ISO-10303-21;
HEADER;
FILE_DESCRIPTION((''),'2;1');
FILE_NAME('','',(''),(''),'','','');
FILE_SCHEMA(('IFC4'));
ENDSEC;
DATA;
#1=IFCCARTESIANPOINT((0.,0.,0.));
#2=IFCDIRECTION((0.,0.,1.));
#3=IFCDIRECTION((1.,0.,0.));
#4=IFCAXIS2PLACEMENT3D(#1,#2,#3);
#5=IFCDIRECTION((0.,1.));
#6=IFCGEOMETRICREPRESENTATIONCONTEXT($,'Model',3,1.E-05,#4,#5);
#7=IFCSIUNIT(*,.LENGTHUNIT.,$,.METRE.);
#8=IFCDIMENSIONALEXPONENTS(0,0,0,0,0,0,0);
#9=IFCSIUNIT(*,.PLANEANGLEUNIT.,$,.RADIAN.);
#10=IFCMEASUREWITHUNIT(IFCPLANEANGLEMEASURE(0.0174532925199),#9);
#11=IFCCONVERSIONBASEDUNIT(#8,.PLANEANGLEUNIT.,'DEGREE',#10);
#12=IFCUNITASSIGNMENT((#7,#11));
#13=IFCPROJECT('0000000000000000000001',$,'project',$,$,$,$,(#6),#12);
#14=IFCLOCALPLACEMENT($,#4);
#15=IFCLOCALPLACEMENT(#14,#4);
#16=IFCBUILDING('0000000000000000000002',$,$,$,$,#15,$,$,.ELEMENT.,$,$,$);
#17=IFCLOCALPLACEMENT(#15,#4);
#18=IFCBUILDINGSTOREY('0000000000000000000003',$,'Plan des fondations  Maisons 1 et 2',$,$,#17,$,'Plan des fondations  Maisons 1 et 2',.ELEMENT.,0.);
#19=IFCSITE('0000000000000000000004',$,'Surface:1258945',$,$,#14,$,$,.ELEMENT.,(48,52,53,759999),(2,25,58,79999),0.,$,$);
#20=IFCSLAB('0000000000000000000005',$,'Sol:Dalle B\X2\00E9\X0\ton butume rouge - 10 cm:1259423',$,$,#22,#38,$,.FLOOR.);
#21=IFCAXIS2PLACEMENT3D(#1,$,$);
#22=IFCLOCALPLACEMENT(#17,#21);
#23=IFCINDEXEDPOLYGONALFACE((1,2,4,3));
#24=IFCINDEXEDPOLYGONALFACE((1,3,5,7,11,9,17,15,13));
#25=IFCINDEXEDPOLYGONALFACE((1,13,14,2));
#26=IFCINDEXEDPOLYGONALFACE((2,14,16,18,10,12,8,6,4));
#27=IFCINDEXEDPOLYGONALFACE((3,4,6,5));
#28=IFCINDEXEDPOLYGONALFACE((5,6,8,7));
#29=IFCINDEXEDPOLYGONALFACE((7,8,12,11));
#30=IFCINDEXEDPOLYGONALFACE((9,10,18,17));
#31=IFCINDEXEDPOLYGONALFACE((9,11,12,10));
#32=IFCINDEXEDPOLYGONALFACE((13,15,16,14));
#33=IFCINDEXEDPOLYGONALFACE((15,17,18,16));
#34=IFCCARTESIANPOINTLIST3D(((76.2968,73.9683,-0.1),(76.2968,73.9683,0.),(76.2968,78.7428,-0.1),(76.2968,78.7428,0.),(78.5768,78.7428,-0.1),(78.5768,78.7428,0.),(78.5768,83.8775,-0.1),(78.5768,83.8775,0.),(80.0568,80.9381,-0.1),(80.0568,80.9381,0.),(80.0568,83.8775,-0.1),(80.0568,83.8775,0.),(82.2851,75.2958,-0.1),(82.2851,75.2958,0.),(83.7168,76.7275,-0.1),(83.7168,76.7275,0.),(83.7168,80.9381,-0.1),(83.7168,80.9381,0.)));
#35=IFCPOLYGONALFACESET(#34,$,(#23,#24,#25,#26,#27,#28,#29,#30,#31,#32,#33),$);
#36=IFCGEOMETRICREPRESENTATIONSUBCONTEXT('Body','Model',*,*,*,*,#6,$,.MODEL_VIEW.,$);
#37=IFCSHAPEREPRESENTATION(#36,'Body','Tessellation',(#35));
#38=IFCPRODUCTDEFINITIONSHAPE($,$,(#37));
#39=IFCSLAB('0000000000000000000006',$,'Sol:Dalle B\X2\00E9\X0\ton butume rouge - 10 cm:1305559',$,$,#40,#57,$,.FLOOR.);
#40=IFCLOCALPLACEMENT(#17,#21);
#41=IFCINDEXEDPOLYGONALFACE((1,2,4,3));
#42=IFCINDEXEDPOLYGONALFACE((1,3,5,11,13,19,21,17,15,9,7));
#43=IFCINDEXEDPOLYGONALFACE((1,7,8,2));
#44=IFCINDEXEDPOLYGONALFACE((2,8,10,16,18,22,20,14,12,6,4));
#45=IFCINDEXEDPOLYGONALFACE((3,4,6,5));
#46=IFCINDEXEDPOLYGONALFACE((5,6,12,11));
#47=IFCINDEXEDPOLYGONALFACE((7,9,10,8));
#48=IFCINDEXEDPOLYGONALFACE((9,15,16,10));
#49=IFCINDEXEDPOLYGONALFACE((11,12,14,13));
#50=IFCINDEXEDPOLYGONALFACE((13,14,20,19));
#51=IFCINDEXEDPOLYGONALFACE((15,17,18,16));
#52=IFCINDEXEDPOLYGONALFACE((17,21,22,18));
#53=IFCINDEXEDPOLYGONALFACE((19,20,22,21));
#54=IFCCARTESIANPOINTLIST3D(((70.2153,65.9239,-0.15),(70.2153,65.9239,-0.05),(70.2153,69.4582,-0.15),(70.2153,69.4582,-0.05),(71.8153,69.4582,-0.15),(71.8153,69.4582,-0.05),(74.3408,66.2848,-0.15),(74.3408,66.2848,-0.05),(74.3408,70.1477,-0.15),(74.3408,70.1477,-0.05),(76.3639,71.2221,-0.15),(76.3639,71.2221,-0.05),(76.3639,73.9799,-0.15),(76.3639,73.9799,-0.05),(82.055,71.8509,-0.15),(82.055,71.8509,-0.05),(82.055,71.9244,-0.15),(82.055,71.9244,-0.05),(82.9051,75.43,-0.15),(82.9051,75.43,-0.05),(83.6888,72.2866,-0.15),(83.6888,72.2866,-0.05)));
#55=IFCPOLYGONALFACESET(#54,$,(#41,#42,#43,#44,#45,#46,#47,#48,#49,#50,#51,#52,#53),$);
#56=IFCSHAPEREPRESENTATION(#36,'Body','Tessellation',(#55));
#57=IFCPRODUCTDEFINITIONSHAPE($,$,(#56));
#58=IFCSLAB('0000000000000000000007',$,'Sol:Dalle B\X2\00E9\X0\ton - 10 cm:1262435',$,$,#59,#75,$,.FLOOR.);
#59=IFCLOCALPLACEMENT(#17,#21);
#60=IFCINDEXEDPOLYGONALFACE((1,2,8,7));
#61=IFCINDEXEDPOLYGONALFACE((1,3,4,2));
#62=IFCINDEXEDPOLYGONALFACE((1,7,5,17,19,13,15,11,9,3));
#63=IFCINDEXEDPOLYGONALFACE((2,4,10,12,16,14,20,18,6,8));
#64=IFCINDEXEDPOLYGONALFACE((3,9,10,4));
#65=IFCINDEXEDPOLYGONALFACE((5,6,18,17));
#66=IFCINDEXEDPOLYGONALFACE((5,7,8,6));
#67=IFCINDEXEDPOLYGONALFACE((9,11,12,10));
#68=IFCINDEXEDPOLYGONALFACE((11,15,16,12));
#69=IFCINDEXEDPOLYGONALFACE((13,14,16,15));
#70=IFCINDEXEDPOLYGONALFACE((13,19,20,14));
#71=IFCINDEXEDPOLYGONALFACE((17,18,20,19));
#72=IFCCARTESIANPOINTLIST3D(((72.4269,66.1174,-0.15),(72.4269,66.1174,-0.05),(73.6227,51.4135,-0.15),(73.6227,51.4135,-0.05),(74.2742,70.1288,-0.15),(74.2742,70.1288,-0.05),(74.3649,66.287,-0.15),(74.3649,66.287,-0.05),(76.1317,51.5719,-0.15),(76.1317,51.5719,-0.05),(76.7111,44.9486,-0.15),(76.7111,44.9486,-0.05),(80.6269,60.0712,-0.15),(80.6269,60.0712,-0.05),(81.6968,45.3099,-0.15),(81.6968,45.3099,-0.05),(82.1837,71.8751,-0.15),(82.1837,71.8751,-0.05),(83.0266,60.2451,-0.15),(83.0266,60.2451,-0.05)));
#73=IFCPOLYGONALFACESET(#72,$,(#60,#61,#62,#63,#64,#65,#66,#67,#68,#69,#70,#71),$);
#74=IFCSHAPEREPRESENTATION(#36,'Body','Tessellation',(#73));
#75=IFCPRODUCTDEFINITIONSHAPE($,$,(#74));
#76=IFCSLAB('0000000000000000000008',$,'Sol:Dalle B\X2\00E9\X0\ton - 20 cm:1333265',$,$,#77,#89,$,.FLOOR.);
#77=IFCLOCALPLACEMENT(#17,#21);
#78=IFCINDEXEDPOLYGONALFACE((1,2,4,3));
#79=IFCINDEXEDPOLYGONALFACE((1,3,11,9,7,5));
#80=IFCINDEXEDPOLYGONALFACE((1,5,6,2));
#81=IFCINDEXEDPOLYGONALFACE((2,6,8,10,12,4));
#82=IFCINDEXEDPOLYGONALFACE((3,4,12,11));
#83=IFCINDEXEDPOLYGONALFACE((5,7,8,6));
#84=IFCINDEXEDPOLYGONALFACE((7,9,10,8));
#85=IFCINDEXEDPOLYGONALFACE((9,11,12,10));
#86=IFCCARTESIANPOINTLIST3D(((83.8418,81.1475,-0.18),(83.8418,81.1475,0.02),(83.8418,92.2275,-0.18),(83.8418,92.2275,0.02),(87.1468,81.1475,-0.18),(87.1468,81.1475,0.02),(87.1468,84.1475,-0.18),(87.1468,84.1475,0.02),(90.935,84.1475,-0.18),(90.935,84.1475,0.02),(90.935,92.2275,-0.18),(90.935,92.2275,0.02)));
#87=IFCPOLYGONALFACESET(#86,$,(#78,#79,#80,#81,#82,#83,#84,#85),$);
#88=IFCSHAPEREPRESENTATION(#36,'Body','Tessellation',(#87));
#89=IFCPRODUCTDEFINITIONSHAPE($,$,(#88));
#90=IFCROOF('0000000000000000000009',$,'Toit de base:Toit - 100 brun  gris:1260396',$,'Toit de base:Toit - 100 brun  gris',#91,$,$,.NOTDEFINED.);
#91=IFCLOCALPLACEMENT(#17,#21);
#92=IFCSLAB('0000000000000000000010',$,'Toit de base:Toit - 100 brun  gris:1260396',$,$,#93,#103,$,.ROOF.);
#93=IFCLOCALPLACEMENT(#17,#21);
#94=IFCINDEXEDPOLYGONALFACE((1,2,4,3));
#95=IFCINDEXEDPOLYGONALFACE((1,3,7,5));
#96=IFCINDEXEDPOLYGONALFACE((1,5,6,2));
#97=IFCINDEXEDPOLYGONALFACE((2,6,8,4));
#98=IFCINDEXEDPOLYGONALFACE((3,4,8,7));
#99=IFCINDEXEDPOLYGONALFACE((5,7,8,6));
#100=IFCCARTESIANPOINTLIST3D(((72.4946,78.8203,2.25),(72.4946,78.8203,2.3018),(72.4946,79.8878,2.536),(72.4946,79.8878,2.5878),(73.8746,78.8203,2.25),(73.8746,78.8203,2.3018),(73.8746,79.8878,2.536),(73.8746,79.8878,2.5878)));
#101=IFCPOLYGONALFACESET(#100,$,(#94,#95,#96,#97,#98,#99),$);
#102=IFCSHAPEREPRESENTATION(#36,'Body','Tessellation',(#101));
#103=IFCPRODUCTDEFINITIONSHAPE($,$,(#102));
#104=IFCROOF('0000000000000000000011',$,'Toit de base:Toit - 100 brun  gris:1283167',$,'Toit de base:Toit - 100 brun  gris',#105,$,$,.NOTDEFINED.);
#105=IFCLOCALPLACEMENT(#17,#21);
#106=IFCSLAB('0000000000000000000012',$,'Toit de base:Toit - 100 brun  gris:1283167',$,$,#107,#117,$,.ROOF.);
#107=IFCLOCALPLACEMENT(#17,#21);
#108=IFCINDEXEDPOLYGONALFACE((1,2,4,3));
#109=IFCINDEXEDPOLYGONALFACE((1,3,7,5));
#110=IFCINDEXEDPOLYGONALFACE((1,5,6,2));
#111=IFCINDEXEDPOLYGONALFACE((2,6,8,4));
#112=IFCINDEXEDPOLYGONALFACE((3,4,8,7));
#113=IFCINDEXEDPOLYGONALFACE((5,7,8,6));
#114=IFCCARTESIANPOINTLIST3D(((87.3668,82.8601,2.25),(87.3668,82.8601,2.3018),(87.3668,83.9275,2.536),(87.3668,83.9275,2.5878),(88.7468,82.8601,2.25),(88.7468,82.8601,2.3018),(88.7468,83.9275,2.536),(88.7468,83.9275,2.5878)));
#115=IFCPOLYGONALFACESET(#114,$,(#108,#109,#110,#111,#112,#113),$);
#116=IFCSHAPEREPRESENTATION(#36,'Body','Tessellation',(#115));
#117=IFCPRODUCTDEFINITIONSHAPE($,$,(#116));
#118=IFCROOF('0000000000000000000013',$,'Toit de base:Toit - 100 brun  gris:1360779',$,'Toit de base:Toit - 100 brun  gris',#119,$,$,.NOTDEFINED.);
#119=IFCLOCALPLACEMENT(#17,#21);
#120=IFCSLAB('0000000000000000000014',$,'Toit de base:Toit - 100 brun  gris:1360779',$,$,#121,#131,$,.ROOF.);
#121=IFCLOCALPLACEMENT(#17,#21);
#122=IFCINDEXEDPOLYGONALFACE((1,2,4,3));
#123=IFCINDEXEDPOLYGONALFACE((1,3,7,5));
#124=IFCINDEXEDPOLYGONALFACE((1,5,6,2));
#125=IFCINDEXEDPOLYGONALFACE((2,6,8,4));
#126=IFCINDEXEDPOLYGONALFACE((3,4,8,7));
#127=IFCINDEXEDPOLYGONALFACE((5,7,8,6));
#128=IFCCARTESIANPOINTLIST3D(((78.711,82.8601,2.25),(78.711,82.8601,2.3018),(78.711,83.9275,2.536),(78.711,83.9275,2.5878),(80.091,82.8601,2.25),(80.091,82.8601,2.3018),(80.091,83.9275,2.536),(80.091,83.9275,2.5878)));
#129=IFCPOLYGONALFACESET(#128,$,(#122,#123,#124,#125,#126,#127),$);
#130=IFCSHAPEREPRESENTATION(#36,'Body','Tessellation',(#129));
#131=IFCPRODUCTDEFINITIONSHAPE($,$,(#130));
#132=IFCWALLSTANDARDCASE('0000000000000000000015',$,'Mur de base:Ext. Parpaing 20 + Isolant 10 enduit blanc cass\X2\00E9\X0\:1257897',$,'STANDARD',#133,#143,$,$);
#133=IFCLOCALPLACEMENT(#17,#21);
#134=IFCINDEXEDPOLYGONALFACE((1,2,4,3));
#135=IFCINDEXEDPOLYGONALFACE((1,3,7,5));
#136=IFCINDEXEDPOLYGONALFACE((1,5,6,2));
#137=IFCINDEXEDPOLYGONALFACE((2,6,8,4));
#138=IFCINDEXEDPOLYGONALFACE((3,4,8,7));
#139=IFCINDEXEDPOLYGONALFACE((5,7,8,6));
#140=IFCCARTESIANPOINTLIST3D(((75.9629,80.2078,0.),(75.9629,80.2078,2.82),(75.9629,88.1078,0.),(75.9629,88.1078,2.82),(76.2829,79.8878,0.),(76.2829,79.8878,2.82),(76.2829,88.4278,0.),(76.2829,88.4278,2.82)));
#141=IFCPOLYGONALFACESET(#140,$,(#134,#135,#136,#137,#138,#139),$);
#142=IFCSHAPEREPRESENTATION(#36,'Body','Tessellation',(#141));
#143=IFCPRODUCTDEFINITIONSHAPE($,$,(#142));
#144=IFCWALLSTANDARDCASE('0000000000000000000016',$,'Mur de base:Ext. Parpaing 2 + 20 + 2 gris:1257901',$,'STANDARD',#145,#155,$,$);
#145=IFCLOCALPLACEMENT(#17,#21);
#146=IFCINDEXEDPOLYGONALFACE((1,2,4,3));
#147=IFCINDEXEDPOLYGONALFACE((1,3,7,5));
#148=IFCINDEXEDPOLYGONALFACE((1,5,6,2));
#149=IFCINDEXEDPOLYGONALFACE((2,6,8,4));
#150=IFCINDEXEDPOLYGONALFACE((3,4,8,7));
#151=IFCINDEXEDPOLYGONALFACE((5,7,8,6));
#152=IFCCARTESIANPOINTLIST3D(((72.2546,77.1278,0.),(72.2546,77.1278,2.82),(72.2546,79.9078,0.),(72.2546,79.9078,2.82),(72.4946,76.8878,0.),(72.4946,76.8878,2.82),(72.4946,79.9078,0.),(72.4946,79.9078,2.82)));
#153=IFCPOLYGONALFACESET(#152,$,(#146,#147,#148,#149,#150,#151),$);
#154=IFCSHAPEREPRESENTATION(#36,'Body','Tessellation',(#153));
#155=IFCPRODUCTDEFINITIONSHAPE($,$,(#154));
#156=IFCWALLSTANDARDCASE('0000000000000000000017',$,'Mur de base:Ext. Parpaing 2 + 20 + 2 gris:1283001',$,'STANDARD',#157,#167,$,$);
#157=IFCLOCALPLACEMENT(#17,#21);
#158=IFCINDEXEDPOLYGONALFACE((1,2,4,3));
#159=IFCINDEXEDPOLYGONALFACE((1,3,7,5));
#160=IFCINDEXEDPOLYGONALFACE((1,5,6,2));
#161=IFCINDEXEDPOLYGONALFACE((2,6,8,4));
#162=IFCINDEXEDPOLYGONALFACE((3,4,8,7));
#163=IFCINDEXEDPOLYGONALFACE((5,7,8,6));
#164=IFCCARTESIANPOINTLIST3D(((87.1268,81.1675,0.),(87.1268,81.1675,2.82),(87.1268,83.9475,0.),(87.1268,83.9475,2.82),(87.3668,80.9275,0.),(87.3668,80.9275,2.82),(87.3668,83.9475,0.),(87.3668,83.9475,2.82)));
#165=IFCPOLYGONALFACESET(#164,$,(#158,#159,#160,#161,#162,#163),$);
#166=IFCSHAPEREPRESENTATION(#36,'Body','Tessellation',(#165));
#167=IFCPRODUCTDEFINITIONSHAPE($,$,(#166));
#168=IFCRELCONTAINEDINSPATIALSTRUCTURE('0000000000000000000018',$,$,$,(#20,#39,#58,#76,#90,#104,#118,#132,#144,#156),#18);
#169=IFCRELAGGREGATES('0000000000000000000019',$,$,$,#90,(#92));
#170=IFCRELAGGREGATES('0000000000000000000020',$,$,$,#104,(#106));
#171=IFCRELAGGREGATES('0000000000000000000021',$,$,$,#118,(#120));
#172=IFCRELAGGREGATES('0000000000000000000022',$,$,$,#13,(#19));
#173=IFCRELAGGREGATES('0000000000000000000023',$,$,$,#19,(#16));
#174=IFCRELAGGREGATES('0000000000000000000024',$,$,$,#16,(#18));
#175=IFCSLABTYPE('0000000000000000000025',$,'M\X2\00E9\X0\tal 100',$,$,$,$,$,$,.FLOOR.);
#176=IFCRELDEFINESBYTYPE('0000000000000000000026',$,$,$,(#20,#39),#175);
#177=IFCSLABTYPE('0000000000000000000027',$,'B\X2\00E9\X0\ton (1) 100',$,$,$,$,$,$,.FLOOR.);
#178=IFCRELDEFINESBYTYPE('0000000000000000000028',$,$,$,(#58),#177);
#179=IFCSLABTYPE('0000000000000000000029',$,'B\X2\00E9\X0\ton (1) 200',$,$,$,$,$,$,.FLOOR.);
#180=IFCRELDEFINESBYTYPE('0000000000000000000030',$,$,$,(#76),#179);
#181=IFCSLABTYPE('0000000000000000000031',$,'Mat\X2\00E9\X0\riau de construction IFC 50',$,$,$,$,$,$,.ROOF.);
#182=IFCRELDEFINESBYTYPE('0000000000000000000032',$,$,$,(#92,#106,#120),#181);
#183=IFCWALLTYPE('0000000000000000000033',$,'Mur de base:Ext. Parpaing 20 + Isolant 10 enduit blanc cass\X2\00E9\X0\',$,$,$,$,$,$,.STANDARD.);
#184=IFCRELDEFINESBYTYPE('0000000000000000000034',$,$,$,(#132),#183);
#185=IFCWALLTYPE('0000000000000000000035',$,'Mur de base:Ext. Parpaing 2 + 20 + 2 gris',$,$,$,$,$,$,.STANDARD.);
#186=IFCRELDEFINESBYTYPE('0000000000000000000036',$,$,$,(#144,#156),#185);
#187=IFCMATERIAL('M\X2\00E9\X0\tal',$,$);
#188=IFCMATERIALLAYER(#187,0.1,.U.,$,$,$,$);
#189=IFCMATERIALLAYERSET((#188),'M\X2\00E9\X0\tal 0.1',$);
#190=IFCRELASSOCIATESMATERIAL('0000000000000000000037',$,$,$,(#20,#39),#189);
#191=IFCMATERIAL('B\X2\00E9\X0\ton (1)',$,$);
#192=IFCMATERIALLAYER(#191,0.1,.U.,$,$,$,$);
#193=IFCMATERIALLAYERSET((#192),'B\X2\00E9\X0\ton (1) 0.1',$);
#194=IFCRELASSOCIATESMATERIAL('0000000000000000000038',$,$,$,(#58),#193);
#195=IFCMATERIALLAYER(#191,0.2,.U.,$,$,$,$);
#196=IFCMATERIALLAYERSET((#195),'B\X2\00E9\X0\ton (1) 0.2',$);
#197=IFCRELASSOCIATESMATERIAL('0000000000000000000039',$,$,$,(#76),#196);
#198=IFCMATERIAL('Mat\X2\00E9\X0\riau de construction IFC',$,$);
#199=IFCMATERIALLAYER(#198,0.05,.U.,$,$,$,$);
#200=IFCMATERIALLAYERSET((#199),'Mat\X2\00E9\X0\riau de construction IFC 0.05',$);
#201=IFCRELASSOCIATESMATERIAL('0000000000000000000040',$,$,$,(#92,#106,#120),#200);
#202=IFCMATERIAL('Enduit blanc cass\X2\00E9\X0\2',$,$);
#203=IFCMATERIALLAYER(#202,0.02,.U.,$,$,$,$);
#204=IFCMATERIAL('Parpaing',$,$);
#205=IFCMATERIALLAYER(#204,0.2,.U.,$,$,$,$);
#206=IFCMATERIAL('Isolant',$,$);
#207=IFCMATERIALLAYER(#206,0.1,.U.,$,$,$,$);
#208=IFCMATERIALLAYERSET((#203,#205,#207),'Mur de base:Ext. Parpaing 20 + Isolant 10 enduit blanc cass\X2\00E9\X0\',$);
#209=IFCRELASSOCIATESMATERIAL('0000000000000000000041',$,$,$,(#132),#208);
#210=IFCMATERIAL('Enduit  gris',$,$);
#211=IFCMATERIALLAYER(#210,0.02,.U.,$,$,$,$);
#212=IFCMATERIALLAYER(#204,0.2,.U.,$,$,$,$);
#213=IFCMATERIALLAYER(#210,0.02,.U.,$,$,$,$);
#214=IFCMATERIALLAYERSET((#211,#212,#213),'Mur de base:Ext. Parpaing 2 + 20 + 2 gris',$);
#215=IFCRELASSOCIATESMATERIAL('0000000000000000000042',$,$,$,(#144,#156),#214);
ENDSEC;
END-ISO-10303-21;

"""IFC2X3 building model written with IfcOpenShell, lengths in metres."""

from ifc_helpers import new_model, entity, si_unit, converted_unit, direction, frame, origin_with_axes, place, context, subcontext, project, spatial, polyline, outline, extrude, material, layer, layer_set, layer_usage, type_object, element, aggregate, save


model = new_model("IFC2X3")

# Units and contexts
model_context = context("Model", 3, precision=1e-05, world=origin_with_axes(), true_north=direction((0.0, 1.0)))
body_context = subcontext(model_context, "Body", "Model", "MODEL_VIEW")
ifc_project = project(units=[si_unit("LENGTHUNIT", "METRE"), converted_unit("PLANEANGLEUNIT", "DEGREE", entity("IfcPlaneAngleMeasure", 0.0174532925199), si_unit("PLANEANGLEUNIT", "RADIAN"), dimensions=[0, 0, 0, 0, 0, 0, 0])], contexts=[model_context])

# Site, building, storey
site_placement = place(None, origin_with_axes())
site = spatial("IfcSite", under=ifc_project, at=site_placement, Name="Surface:1258945", CompositionType="ELEMENT", RefLatitude=(48, 52, 53, 759999), RefLongitude=(2, 25, 58, 79999), RefElevation=0.0)
building_placement = place(site_placement, origin_with_axes())
building = spatial("IfcBuilding", under=site, at=building_placement, CompositionType="ELEMENT")
storey_placement = place(building_placement, origin_with_axes())
storey = spatial("IfcBuildingStorey", under=building, at=storey_placement, Name="Plan des fondations  Maisons 1 et 2", LongName="Plan des fondations  Maisons 1 et 2", CompositionType="ELEMENT", Elevation=0.0)

# Slabs
ifc_material_1 = material(Name="Métal")
ifc_layer_1 = layer(ifc_material_1, 0.1, ventilated="UNKNOWN")
ifc_layer_set_1 = layer_set([ifc_layer_1], Name="Métal 0.1")
ifc_layer_usage_1 = layer_usage(ifc_layer_set_1, "AXIS3", "NEGATIVE", 0.1)
slab_type_1 = type_object("IfcSlabType", Name="Métal 100", PredefinedType="FLOOR")
slab_1_placement = place(storey_placement, frame((76.2968, 73.9683, 0.0), z_axis=(0.0, 0.0, 1.0), x_axis=(1.0, 0.0, 0.0)))
element("IfcSlab", 1, at=slab_1_placement, inside=storey, type_object=slab_type_1, material=ifc_layer_usage_1, Name="Sol:Dalle Béton butume rouge - 10 cm:1259423", PredefinedType="FLOOR", context=body_context, shape_type="SweptSolid", body=[
    extrude(outline(polyline([(0.0, 0.0), (5.9883, 1.3276), (7.42, 2.7593), (7.42, 6.9698), (3.76, 6.9698), (3.76, 9.9093), (2.28, 9.9093), (2.28, 4.7745), (0.0, 4.7745), (0.0, 0.0)])), frame((0.0, 0.0, -0.1), z_axis=(0.0, 0.0, 1.0), x_axis=(1.0, 0.0, 0.0)), (0.0, 0.0, 1.0), 0.1),
])
ifc_layer_usage_2 = layer_usage(ifc_layer_set_1, "AXIS3", "NEGATIVE", 0.1)
slab_2_placement = place(storey_placement, frame((70.2153, 65.9239, -0.05), z_axis=(0.0, 0.0, 1.0), x_axis=(1.0, 0.0, 0.0)))
element("IfcSlab", 2, at=slab_2_placement, inside=storey, type_object=slab_type_1, material=ifc_layer_usage_2, Name="Sol:Dalle Béton butume rouge - 10 cm:1305559", PredefinedType="FLOOR", context=body_context, shape_type="SweptSolid", body=[
    extrude(outline(polyline([(0.0, 0.0), (4.1255, 0.3609), (4.1255, 4.2238), (11.8397, 5.927), (11.8397, 6.0005), (13.4735, 6.3627), (12.6897, 9.5061), (6.1485, 8.056), (6.1485, 5.2982), (1.6, 3.5343), (0.0, 3.5343), (0.0, 0.0)])), frame((0.0, 0.0, -0.1), z_axis=(0.0, 0.0, 1.0), x_axis=(1.0, 0.0, 0.0)), (0.0, 0.0, 1.0), 0.1),
])
ifc_material_2 = material(Name="Béton (1)")
ifc_layer_2 = layer(ifc_material_2, 0.1, ventilated="UNKNOWN")
ifc_layer_set_2 = layer_set([ifc_layer_2], Name="Béton (1) 0.1")
ifc_layer_usage_3 = layer_usage(ifc_layer_set_2, "AXIS3", "NEGATIVE", 0.1)
slab_type_2 = type_object("IfcSlabType", Name="Béton (1) 100", PredefinedType="FLOOR")
slab_3_placement = place(storey_placement, frame((82.1837, 71.8751, -0.05), z_axis=(0.0, 0.0, 1.0), x_axis=(1.0, 0.0, 0.0)))
element("IfcSlab", 3, at=slab_3_placement, inside=storey, type_object=slab_type_2, material=ifc_layer_usage_3, Name="Sol:Dalle Béton - 10 cm:1262435", PredefinedType="FLOOR", context=body_context, shape_type="SweptSolid", body=[
    extrude(outline(polyline([(0.0, 0.0), (-7.9095, -1.7463), (-7.8187, -5.5881), (-9.7568, -5.7577), (-8.561, -20.4616), (-6.052, -20.3032), (-5.4725, -26.9265), (-0.4869, -26.5651), (-1.5567, -11.8039), (0.8429, -11.63), (0.0, 0.0)])), frame((0.0, 0.0, -0.1), z_axis=(0.0, 0.0, 1.0), x_axis=(1.0, 0.0, 0.0)), (0.0, 0.0, 1.0), 0.1),
])
ifc_layer_3 = layer(ifc_material_2, 0.2, ventilated="UNKNOWN")
ifc_layer_set_3 = layer_set([ifc_layer_3], Name="Béton (1) 0.2")
ifc_layer_usage_4 = layer_usage(ifc_layer_set_3, "AXIS3", "NEGATIVE", 0.2)
slab_type_3 = type_object("IfcSlabType", Name="Béton (1) 200", PredefinedType="FLOOR")
slab_4_placement = place(storey_placement, frame((83.8418, 81.1475, 0.02), z_axis=(0.0, 0.0, 1.0), x_axis=(1.0, 0.0, 0.0)))
element("IfcSlab", 4, at=slab_4_placement, inside=storey, type_object=slab_type_3, material=ifc_layer_usage_4, Name="Sol:Dalle Béton - 20 cm:1333265", PredefinedType="FLOOR", context=body_context, shape_type="SweptSolid", body=[
    extrude(outline(polyline([(0.0, 0.0), (3.305, 0.0), (3.305, 3.0), (7.0933, 3.0), (7.0933, 11.08), (0.0, 11.08), (0.0, 0.0)])), frame((0.0, 0.0, -0.2), z_axis=(0.0, 0.0, 1.0), x_axis=(1.0, 0.0, 0.0)), (0.0, 0.0, 1.0), 0.2),
])

# Roofs, slabs
roof_1_placement = place(storey_placement, origin_with_axes())
roof_1 = element("IfcRoof", 5, at=roof_1_placement, inside=storey, Name="Toit de base:Toit - 100 brun  gris:1260396", ObjectType="Toit de base:Toit - 100 brun  gris", ShapeType="NOTDEFINED")
ifc_material_3 = material(Name="Matériau de construction IFC")
ifc_layer_4 = layer(ifc_material_3, 0.05, ventilated="UNKNOWN")
ifc_layer_set_4 = layer_set([ifc_layer_4], Name="Matériau de construction IFC 0.05")
ifc_layer_usage_5 = layer_usage(ifc_layer_set_4, "AXIS3", "NEGATIVE", 0.05)
slab_type_4 = type_object("IfcSlabType", Name="Matériau de construction IFC 50", PredefinedType="ROOF")
slab_5_placement = place(roof_1_placement, frame((72.4946, 79.354, 2.393), z_axis=(0.0, 0.0, 1.0), x_axis=(1.0, 0.0, 0.0)))
slab_5 = element("IfcSlab", 6, at=slab_5_placement, type_object=slab_type_4, material=ifc_layer_usage_5, Name="Toit de base:Toit - 100 brun  gris:1260396", PredefinedType="ROOF", context=body_context, shape_type="SweptSolid", body=[
    extrude(outline(polyline([(0.0, -0.5526), (1.38, -0.5526), (1.38, 0.5526), (0.0, 0.5526), (0.0, -0.5526)])), frame((0.0, 0.0, 0.0), z_axis=(0.0, -0.258819, 0.965926), x_axis=(1.0, 0.0, 0.0)), (0.0, 0.258819, 0.965926), 0.0518),
])
aggregate(roof_1, [slab_5])
roof_2_placement = place(storey_placement, origin_with_axes())
roof_2 = element("IfcRoof", 7, at=roof_2_placement, inside=storey, Name="Toit de base:Toit - 100 brun  gris:1283167", ObjectType="Toit de base:Toit - 100 brun  gris", ShapeType="NOTDEFINED")
ifc_layer_usage_6 = layer_usage(ifc_layer_set_4, "AXIS3", "NEGATIVE", 0.05)
slab_6_placement = place(roof_2_placement, frame((87.3668, 83.3938, 2.393), z_axis=(0.0, 0.0, 1.0), x_axis=(1.0, 0.0, 0.0)))
slab_6 = element("IfcSlab", 8, at=slab_6_placement, type_object=slab_type_4, material=ifc_layer_usage_6, Name="Toit de base:Toit - 100 brun  gris:1283167", PredefinedType="ROOF", context=body_context, shape_type="SweptSolid", body=[
    extrude(outline(polyline([(0.0, -0.5526), (1.38, -0.5526), (1.38, 0.5526), (0.0, 0.5526), (0.0, -0.5526)])), frame((0.0, 0.0, 0.0), z_axis=(0.0, -0.258819, 0.965926), x_axis=(1.0, 0.0, 0.0)), (0.0, 0.258819, 0.965926), 0.0518),
])
aggregate(roof_2, [slab_6])
roof_3_placement = place(storey_placement, origin_with_axes())
roof_3 = element("IfcRoof", 9, at=roof_3_placement, inside=storey, Name="Toit de base:Toit - 100 brun  gris:1360779", ObjectType="Toit de base:Toit - 100 brun  gris", ShapeType="NOTDEFINED")
ifc_layer_usage_7 = layer_usage(ifc_layer_set_4, "AXIS3", "NEGATIVE", 0.05)
slab_7_placement = place(roof_3_placement, frame((78.711, 83.3938, 2.393), z_axis=(0.0, 0.0, 1.0), x_axis=(1.0, 0.0, 0.0)))
slab_7 = element("IfcSlab", 10, at=slab_7_placement, type_object=slab_type_4, material=ifc_layer_usage_7, Name="Toit de base:Toit - 100 brun  gris:1360779", PredefinedType="ROOF", context=body_context, shape_type="SweptSolid", body=[
    extrude(outline(polyline([(0.0, -0.5526), (1.38, -0.5526), (1.38, 0.5526), (0.0, 0.5526), (0.0, -0.5526)])), frame((0.0, 0.0, 0.0), z_axis=(0.0, -0.258819, 0.965926), x_axis=(1.0, 0.0, 0.0)), (0.0, 0.258819, 0.965926), 0.0518),
])
aggregate(roof_3, [slab_7])

# Walls
ifc_material_4 = material(Name="Enduit blanc cassé2")
ifc_layer_5 = layer(ifc_material_4, 0.02, ventilated="UNKNOWN")
ifc_material_5 = material(Name="Parpaing")
ifc_layer_6 = layer(ifc_material_5, 0.2, ventilated="UNKNOWN")
ifc_material_6 = material(Name="Isolant")
ifc_layer_7 = layer(ifc_material_6, 0.1, ventilated="UNKNOWN")
ifc_layer_set_5 = layer_set([ifc_layer_5, ifc_layer_6, ifc_layer_7], Name="Mur de base:Ext. Parpaing 20 + Isolant 10 enduit blanc cassé")
ifc_layer_usage_8 = layer_usage(ifc_layer_set_5, "AXIS2", "POSITIVE", -0.16)
wall_type_1 = type_object("IfcWallType", Name="Mur de base:Ext. Parpaing 20 + Isolant 10 enduit blanc cassé", PredefinedType="STANDARD")
wall_1_placement = place(storey_placement, frame((76.1229, 80.0478, 0.0), z_axis=(0.0, 0.0, 1.0), x_axis=(0.0, 1.0, 0.0)))
element("IfcWallStandardCase", 11, at=wall_1_placement, inside=storey, type_object=wall_type_1, material=ifc_layer_usage_8, Name="Mur de base:Ext. Parpaing 20 + Isolant 10 enduit blanc cassé:1257897", ObjectType="STANDARD", context=body_context, shape_type="SweptSolid", body=[
    extrude(outline(polyline([(-0.16, -0.16), (8.38, -0.16), (8.06, 0.16), (0.16, 0.16), (-0.16, -0.16)])), origin_with_axes(), (0.0, 0.0, 1.0), 2.82),
])
ifc_material_7 = material(Name="Enduit  gris")
ifc_layer_8 = layer(ifc_material_7, 0.02, ventilated="UNKNOWN")
ifc_layer_9 = layer(ifc_material_5, 0.2, ventilated="UNKNOWN")
ifc_layer_10 = layer(ifc_material_7, 0.02, ventilated="UNKNOWN")
ifc_layer_set_6 = layer_set([ifc_layer_8, ifc_layer_9, ifc_layer_10], Name="Mur de base:Ext. Parpaing 2 + 20 + 2 gris")
ifc_layer_usage_9 = layer_usage(ifc_layer_set_6, "AXIS2", "POSITIVE", -0.12)
wall_type_2 = type_object("IfcWallType", Name="Mur de base:Ext. Parpaing 2 + 20 + 2 gris", PredefinedType="STANDARD")
wall_2_placement = place(storey_placement, frame((72.3746, 77.0078, 0.0), z_axis=(0.0, 0.0, 1.0), x_axis=(0.0, 1.0, 0.0)))
element("IfcWallStandardCase", 12, at=wall_2_placement, inside=storey, type_object=wall_type_2, material=ifc_layer_usage_9, Name="Mur de base:Ext. Parpaing 2 + 20 + 2 gris:1257901", ObjectType="STANDARD", context=body_context, shape_type="SweptSolid", body=[
    extrude(outline(polyline([(-0.12, -0.12), (2.9, -0.12), (2.9, 0.12), (0.12, 0.12), (-0.12, -0.12)])), origin_with_axes(), (0.0, 0.0, 1.0), 2.82),
])
ifc_layer_usage_10 = layer_usage(ifc_layer_set_6, "AXIS2", "POSITIVE", -0.12)
wall_3_placement = place(storey_placement, frame((87.2468, 81.0475, 0.0), z_axis=(0.0, 0.0, 1.0), x_axis=(0.0, 1.0, 0.0)))
element("IfcWallStandardCase", 13, at=wall_3_placement, inside=storey, type_object=wall_type_2, material=ifc_layer_usage_10, Name="Mur de base:Ext. Parpaing 2 + 20 + 2 gris:1283001", ObjectType="STANDARD", context=body_context, shape_type="SweptSolid", body=[
    extrude(outline(polyline([(-0.12, -0.12), (2.9, -0.12), (2.9, 0.12), (0.12, 0.12), (-0.12, -0.12)])), origin_with_axes(), (0.0, 0.0, 1.0), 2.82),
])

save(model, "model.ifc")
